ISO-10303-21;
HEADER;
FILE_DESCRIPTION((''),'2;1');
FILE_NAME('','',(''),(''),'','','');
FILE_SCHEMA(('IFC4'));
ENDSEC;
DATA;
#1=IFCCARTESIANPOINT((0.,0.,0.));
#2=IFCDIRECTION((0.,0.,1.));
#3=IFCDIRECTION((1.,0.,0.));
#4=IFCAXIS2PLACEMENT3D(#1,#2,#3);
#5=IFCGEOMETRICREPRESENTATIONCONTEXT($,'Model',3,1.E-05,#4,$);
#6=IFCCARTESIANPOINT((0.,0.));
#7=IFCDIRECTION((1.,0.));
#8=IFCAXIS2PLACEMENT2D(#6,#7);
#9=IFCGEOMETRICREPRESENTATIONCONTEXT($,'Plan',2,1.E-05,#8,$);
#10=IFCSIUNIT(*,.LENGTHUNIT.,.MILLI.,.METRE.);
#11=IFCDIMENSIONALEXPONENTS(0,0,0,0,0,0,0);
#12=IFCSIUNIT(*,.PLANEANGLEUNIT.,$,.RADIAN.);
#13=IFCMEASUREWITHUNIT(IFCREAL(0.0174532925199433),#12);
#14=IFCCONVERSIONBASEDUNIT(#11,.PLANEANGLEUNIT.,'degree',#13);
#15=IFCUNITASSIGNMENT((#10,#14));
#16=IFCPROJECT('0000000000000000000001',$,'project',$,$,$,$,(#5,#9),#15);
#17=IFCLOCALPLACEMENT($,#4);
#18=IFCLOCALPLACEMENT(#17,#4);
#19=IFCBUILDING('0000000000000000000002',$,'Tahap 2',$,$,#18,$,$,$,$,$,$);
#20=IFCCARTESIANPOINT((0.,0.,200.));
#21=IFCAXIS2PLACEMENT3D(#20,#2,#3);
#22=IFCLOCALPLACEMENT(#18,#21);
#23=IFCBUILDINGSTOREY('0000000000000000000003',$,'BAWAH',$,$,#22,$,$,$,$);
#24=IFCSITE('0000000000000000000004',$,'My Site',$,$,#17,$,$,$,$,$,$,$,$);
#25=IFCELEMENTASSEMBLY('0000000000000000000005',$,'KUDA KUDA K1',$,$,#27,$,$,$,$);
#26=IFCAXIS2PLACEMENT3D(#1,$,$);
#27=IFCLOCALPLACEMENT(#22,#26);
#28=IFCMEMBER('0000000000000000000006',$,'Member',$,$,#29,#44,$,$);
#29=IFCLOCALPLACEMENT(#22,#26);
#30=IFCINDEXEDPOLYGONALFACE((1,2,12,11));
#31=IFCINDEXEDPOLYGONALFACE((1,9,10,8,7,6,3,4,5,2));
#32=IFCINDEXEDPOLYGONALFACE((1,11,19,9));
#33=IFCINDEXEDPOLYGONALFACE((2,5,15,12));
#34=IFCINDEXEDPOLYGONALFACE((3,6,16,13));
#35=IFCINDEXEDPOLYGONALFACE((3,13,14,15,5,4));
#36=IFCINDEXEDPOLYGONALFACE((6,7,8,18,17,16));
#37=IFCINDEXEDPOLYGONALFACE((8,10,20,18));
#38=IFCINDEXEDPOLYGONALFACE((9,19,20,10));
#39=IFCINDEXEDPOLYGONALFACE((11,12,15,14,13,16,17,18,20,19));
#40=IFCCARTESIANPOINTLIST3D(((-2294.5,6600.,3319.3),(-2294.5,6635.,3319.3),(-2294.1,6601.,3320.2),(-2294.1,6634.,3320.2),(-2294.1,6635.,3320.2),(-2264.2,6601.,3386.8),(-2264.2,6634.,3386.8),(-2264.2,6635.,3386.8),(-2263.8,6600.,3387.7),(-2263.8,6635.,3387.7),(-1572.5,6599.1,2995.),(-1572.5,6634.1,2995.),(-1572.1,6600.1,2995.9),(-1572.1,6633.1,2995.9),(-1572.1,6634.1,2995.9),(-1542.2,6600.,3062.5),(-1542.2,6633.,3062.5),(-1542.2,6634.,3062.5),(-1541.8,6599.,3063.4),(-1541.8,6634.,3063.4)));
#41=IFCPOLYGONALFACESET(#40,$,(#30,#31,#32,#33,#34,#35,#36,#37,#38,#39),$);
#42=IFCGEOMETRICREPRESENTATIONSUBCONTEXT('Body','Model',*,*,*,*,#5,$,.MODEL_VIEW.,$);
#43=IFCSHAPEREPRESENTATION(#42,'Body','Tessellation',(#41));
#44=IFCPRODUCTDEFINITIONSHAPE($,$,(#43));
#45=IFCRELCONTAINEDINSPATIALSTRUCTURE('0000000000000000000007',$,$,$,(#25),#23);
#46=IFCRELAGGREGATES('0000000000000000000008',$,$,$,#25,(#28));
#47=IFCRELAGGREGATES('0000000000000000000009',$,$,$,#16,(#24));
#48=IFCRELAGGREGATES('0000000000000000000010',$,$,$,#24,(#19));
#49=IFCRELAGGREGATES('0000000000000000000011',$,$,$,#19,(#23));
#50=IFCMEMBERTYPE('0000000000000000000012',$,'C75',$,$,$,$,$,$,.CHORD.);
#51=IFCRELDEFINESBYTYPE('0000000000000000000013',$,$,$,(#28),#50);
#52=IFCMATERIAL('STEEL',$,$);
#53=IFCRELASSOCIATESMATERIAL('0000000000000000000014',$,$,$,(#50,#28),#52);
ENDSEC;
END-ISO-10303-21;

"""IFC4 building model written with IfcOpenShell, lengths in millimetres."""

from ifc_helpers import new_model, entity, si_unit, converted_unit, frame, origin_with_axes, origin_2d_with_axis, place, context, subcontext, project, spatial, c_section, extrude, material, material_profile, profile_set, profile_usage, type_object, element, aggregate, save


model = new_model("IFC4")

# Units and contexts
model_context = context("Model", 3, precision=1e-05, world=origin_with_axes())
plan_context = context("Plan", 2, precision=1e-05, world=origin_2d_with_axis())
body_context = subcontext(model_context, "Body", "Model", "MODEL_VIEW")
ifc_project = project(units=[si_unit("LENGTHUNIT", "METRE", prefix="MILLI"), converted_unit("PLANEANGLEUNIT", "degree", entity("IfcReal", 0.0174532925199433), si_unit("PLANEANGLEUNIT", "RADIAN"), dimensions=[0, 0, 0, 0, 0, 0, 0])], contexts=[model_context, plan_context])

# Site, building, storey
site_placement = place(None, origin_with_axes())
site = spatial("IfcSite", under=ifc_project, at=site_placement, Name="My Site")
building_placement = place(site_placement, origin_with_axes())
building = spatial("IfcBuilding", under=site, at=building_placement, Name="Tahap 2")
storey_placement = place(building_placement, frame((0.0, 0.0, 200.0), z_axis=(0.0, 0.0, 1.0), x_axis=(1.0, 0.0, 0.0)))
storey = spatial("IfcBuildingStorey", under=building, at=storey_placement, Name="BAWAH")

# Element assembly, member
assembly_1_placement = place(storey_placement, frame((-1561.5, 6600.1, 3019.6), z_axis=(0.0, 0.0, 1.0), x_axis=(1.0, 0.0, 0.0)))
assembly_1 = element("IfcElementAssembly", 1, at=assembly_1_placement, inside=storey, Name="KUDA KUDA K1")
ifc_material = material(Name="STEEL")
ifc_material_profile = material_profile(ifc_material, c_section(Depth=75.0, Width=35.0, WallThickness=1.0, Girth=1.0, kind="CURVE"))
ifc_profile_set = profile_set([ifc_material_profile])
member_type = type_object("IfcMemberType", Name="C75", PredefinedType="CHORD", material=ifc_profile_set)
ifc_profile_usage_1 = profile_usage(ifc_profile_set, cardinal=9)
member_1_placement = place(assembly_1_placement, frame((-702.4, -0.1, 368.1), z_axis=(0.912207, -0.00122, -0.409728), x_axis=(0.001371, 0.999999, 0.000076)))
member_1 = element("IfcMember", 2, at=member_1_placement, type_object=member_type, material=ifc_profile_usage_1, Name="Member", context=body_context, shape_type="SweptSolid", body=[
    extrude(c_section(Depth=75.0, Width=35.0, WallThickness=1.0, Girth=1.0, kind="CURVE"), frame((17.5, -37.5, 0.0), z_axis=(0.0, 0.0, 1.0), x_axis=(1.0, 0.0, 0.0)), (0.0, 0.0, 1.0), 791.5),
])
aggregate(assembly_1, [member_1])

save(model, "model.ifc")
